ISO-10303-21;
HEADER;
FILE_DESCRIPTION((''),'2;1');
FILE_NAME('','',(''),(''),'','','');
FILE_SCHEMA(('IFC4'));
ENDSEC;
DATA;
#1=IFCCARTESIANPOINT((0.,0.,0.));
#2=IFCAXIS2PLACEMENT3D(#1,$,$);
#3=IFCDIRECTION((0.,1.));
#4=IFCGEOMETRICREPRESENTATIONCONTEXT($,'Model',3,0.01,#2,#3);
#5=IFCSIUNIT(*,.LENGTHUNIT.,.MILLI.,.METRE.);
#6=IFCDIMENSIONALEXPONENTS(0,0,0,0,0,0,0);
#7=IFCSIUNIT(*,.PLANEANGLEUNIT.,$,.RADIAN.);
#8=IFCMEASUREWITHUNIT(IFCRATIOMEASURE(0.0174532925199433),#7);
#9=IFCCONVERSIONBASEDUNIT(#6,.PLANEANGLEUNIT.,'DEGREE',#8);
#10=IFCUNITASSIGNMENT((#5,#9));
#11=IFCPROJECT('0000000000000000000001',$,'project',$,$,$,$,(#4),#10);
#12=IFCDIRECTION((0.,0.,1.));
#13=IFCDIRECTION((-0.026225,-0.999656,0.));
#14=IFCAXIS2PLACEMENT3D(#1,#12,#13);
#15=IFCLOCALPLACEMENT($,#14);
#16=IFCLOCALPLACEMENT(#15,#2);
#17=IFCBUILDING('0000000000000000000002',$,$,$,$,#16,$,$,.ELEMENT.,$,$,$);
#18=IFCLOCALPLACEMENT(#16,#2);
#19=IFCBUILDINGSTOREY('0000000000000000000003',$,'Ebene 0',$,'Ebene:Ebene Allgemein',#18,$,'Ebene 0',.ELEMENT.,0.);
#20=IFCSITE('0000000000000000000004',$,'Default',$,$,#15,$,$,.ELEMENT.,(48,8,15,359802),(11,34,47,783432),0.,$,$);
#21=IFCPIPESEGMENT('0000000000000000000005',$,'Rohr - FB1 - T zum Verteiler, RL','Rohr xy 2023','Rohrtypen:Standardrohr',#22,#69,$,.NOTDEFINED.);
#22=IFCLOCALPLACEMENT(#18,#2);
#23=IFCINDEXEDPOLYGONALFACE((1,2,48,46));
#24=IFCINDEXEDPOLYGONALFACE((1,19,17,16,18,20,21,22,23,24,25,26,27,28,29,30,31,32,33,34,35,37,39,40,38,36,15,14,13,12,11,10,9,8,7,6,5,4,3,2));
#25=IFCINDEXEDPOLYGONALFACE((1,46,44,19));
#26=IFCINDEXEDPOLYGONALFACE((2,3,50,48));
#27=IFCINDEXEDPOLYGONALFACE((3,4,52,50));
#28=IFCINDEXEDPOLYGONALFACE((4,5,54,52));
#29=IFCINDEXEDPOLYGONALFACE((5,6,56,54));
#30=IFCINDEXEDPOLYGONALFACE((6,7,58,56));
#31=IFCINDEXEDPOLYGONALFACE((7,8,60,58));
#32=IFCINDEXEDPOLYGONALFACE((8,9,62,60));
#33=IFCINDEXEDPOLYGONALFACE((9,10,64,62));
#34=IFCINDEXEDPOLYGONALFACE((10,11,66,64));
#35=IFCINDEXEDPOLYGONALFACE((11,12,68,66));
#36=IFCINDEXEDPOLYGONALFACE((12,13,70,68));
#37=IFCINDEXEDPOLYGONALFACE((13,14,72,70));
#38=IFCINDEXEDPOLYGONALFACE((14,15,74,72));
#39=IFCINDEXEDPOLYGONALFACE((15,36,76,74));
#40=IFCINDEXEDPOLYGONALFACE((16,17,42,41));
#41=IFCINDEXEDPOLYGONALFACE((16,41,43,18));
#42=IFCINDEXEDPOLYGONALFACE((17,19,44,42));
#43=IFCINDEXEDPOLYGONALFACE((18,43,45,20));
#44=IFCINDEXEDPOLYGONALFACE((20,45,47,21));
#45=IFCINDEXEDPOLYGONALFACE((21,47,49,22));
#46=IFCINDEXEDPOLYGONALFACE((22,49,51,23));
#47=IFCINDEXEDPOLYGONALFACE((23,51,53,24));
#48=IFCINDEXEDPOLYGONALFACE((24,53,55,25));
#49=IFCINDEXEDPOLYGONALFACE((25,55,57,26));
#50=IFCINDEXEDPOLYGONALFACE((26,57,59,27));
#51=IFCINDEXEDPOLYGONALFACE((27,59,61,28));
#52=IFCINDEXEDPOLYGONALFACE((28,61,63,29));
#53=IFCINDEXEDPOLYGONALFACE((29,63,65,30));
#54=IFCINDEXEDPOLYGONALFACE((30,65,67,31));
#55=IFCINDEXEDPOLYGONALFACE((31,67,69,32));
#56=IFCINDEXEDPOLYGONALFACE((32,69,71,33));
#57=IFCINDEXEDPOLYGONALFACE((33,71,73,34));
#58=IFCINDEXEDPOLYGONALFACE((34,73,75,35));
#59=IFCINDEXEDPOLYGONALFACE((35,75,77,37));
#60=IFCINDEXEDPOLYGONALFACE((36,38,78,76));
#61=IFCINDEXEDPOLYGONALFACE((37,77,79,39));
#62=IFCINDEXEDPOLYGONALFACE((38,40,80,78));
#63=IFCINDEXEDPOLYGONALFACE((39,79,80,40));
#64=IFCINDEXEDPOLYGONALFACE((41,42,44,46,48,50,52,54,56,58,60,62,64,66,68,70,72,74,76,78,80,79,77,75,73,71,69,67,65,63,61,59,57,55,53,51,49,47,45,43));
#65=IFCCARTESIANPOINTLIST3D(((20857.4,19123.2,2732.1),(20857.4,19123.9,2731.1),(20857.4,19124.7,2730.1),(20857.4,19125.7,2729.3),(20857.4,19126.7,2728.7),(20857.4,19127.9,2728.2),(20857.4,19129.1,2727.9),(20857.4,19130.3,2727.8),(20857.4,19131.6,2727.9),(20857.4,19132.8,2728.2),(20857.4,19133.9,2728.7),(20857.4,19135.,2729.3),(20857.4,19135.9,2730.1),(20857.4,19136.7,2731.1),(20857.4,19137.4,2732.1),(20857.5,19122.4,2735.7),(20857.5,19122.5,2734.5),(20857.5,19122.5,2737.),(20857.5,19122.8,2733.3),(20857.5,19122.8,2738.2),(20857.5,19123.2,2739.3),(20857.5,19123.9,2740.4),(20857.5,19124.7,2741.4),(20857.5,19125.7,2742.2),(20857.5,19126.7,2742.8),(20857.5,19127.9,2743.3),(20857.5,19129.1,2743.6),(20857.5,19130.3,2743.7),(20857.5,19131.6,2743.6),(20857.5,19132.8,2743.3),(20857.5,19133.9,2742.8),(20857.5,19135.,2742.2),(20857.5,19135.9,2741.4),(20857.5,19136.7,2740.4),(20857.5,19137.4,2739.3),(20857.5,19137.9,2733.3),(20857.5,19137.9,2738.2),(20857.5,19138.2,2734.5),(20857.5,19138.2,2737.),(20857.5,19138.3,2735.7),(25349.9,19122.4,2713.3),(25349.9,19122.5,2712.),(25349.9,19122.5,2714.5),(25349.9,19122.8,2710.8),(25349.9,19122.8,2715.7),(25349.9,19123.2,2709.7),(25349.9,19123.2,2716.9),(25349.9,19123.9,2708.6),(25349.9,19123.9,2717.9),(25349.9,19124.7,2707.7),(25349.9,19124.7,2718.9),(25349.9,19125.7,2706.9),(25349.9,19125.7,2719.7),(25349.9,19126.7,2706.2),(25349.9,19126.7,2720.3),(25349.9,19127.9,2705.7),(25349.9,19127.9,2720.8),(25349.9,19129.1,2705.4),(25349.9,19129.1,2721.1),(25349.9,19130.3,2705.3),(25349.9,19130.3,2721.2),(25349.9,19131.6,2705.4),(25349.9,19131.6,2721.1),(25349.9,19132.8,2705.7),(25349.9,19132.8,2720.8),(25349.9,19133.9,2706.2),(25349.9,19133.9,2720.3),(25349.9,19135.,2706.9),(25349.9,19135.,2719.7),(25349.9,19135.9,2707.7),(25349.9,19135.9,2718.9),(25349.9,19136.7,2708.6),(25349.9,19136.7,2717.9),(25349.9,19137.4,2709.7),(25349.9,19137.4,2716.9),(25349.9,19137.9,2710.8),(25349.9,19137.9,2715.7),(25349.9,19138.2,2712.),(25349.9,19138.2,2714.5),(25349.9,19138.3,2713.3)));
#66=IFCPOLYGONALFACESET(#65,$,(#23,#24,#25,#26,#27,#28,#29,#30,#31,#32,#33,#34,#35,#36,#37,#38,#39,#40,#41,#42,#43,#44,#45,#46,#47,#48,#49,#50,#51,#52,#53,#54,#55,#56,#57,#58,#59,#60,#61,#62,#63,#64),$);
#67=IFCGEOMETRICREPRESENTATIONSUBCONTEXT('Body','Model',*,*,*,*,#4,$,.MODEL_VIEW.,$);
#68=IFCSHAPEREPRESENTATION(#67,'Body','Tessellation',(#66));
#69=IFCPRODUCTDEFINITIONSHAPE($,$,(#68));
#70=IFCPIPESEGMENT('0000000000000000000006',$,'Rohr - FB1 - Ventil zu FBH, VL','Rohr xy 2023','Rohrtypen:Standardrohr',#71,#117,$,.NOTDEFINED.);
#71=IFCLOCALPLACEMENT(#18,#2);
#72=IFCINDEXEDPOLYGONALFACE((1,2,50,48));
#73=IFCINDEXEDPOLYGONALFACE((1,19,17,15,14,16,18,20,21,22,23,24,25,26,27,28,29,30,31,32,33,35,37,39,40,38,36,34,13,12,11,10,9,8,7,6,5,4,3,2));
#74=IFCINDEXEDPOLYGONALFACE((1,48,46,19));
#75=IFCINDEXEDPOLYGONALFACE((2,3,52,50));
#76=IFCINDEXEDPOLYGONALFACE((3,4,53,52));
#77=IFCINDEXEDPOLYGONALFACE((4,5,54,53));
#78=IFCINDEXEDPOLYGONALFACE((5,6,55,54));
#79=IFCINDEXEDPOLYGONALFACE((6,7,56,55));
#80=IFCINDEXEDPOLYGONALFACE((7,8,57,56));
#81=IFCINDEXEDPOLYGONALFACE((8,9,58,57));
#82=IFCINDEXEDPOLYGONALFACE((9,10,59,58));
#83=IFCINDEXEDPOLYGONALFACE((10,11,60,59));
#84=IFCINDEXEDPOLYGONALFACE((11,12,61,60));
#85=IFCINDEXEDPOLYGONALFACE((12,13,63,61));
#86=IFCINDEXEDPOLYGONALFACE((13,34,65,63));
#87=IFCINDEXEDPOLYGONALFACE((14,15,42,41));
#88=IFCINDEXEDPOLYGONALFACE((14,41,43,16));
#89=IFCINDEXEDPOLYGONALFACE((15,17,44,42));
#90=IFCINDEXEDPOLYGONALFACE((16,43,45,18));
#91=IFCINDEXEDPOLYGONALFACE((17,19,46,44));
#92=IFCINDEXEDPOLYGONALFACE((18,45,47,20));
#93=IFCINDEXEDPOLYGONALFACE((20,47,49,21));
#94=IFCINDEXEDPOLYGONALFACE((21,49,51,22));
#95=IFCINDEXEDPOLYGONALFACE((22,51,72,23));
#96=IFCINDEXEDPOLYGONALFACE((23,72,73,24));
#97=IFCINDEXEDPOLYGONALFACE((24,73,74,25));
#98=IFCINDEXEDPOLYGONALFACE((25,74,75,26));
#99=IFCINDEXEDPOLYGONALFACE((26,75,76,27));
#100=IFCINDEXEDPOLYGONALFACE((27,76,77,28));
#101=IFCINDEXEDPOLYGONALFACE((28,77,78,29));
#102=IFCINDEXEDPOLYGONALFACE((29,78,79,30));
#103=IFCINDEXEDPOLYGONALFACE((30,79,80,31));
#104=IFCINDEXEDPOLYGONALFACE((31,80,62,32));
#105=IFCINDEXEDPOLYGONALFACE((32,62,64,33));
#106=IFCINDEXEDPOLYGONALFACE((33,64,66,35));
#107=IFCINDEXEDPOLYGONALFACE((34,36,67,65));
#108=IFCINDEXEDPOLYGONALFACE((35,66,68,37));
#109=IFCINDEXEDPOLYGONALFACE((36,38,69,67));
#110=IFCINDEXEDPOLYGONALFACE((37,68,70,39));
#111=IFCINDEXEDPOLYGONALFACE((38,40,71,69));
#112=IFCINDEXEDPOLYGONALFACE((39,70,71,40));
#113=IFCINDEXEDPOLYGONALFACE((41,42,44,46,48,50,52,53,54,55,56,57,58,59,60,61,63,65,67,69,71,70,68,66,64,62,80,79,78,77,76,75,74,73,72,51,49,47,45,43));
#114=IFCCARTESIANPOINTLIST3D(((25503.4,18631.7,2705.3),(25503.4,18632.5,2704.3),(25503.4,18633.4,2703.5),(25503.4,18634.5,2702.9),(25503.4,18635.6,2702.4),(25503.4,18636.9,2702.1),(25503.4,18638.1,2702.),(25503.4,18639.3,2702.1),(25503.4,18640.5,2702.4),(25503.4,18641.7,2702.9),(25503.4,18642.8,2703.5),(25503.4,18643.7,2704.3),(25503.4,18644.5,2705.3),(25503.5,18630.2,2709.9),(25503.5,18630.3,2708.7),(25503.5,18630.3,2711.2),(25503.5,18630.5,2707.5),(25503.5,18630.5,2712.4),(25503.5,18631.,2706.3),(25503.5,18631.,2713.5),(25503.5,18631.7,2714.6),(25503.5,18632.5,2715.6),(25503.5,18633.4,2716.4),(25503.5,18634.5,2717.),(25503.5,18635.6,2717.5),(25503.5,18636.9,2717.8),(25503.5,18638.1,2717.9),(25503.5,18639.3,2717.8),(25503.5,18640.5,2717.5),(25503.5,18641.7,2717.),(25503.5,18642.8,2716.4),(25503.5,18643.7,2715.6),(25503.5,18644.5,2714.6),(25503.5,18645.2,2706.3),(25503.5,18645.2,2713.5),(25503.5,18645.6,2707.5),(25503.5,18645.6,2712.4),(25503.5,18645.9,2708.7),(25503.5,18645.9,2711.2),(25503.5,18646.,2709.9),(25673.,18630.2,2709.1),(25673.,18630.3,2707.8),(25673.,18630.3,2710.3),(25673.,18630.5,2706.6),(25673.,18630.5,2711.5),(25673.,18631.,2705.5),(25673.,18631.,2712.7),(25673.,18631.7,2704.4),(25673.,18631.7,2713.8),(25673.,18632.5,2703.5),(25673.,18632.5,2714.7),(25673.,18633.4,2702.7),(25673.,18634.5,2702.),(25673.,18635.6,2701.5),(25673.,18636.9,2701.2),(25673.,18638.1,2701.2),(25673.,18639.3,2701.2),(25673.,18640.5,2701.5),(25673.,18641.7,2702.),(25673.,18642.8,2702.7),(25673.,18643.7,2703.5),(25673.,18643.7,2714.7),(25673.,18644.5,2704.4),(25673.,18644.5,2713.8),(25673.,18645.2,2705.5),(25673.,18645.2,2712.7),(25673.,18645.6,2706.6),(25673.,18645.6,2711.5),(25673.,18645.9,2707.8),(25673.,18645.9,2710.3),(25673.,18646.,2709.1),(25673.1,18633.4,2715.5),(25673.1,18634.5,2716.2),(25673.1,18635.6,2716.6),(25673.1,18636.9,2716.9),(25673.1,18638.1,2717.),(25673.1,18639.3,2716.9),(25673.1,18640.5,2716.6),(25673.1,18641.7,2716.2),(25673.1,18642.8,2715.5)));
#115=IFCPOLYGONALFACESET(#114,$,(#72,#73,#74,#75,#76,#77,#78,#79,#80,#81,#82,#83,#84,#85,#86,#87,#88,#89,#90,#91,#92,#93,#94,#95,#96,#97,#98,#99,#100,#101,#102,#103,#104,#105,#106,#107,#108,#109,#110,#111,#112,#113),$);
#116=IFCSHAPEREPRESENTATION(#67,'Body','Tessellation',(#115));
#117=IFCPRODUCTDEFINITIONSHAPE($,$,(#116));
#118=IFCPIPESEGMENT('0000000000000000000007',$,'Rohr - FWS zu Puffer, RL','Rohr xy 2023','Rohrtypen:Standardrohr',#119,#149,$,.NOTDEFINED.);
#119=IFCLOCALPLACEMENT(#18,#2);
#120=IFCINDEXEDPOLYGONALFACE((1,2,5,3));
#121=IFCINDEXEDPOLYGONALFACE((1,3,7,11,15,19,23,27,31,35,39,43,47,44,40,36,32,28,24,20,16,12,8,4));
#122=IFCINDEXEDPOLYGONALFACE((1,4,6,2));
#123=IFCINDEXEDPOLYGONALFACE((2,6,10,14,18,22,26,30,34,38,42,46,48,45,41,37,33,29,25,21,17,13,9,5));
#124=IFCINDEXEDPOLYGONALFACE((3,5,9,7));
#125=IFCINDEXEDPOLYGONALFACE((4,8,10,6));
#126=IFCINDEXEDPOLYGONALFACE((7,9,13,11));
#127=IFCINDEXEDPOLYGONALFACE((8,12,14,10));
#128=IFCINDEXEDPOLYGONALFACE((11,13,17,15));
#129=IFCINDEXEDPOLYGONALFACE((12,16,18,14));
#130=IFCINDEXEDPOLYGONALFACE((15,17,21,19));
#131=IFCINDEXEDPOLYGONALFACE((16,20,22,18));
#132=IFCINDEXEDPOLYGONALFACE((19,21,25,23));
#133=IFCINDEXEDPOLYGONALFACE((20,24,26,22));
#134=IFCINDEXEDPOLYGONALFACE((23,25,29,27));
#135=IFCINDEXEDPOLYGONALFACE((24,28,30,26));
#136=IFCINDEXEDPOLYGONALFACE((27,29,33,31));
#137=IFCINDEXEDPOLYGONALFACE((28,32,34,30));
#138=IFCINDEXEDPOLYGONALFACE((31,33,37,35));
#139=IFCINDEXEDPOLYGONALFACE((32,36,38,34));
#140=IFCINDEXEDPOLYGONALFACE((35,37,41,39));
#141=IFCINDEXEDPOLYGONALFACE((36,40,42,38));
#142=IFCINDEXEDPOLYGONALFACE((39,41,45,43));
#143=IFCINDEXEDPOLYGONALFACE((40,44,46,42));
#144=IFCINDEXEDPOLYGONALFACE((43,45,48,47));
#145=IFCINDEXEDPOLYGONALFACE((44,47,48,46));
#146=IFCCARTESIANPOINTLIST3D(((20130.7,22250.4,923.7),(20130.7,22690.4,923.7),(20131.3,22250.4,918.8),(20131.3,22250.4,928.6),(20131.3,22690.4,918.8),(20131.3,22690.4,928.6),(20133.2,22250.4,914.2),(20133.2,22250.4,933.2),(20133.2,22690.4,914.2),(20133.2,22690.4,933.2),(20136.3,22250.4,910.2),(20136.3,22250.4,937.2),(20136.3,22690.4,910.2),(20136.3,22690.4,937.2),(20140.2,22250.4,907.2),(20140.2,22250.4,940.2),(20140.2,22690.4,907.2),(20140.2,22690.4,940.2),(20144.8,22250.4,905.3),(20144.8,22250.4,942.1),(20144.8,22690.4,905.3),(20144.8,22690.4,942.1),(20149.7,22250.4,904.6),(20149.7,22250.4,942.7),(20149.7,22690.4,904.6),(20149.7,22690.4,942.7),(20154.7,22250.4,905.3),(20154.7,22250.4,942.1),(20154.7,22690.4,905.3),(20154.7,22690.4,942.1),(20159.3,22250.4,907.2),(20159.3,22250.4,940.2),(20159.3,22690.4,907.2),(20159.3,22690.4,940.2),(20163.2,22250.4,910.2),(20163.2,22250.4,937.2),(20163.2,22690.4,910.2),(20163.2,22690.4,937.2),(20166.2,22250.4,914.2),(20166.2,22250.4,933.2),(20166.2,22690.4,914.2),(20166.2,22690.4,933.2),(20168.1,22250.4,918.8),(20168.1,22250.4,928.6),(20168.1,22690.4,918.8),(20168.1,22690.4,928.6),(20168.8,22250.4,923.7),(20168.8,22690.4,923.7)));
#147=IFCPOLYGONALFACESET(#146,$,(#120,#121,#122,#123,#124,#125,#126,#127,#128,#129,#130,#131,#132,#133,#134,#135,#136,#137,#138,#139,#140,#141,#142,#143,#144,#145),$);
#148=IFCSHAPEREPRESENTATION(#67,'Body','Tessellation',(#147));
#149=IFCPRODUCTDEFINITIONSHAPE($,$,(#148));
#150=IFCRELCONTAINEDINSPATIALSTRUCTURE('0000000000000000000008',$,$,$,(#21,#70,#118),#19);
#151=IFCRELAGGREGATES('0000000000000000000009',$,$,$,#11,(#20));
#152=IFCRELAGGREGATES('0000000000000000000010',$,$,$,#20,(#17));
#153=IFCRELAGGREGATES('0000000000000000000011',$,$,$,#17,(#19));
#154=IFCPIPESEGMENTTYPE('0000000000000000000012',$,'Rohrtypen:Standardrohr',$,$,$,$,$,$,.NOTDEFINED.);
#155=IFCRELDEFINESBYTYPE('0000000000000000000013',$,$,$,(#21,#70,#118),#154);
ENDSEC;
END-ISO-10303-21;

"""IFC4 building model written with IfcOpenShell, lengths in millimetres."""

from ifc_helpers import new_model, entity, si_unit, converted_unit, direction, frame, origin, place, context, subcontext, project, spatial, indexed_curve, outline, extrude, type_object, element, save


model = new_model("IFC4")

# Units and contexts
model_context = context("Model", 3, precision=0.01, world=origin(), true_north=direction((0.0, 1.0)))
body_context = subcontext(model_context, "Body", "Model", "MODEL_VIEW")
ifc_project = project(units=[si_unit("LENGTHUNIT", "METRE", prefix="MILLI"), converted_unit("PLANEANGLEUNIT", "DEGREE", entity("IfcRatioMeasure", 0.0174532925199433), si_unit("PLANEANGLEUNIT", "RADIAN"), dimensions=[0, 0, 0, 0, 0, 0, 0])], contexts=[model_context])

# Site, building, storey
site_placement = place(None, frame((0.0, 0.0, 0.0), z_axis=(0.0, 0.0, 1.0), x_axis=(-0.026225, -0.999656, 0.0)))
site = spatial("IfcSite", under=ifc_project, at=site_placement, Name="Default", CompositionType="ELEMENT", RefLatitude=(48, 8, 15, 359802), RefLongitude=(11, 34, 47, 783432), RefElevation=0.0)
building_placement = place(site_placement, origin())
building = spatial("IfcBuilding", under=site, at=building_placement, CompositionType="ELEMENT")
storey_placement = place(building_placement, origin())
storey = spatial("IfcBuildingStorey", under=building, at=storey_placement, Name="Ebene 0", ObjectType="Ebene:Ebene Allgemein", LongName="Ebene 0", CompositionType="ELEMENT", Elevation=0.0)

# Pipe segments
pipe_segment_type = type_object("IfcPipeSegmentType", Name="Rohrtypen:Standardrohr", PredefinedType="NOTDEFINED")
pipe_segment_1_placement = place(storey_placement, origin())
element("IfcPipeSegment", 1, at=pipe_segment_1_placement, inside=storey, type_object=pipe_segment_type, Name="Rohr - FB1 - T zum Verteiler, RL", Description="Rohr xy 2023", ObjectType="Rohrtypen:Standardrohr", PredefinedType="NOTDEFINED", context=body_context, shape_type="SweptSolid", body=[
    extrude(outline(indexed_curve([(7.9, 0.0), (7.8, 1.2), (7.6, 2.5), (7.1, 3.6), (6.4, 4.7), (5.6, 5.6), (4.7, 6.4), (3.6, 7.1), (2.5, 7.6), (1.2, 7.8), (0.0, 7.9), (-1.2, 7.8), (-2.5, 7.6), (-3.6, 7.1), (-4.7, 6.4), (-5.6, 5.6), (-6.4, 4.7), (-7.1, 3.6), (-7.6, 2.5), (-7.8, 1.2), (-7.9, 0.0), (-7.8, -1.2), (-7.6, -2.5), (-7.1, -3.6), (-6.4, -4.7), (-5.6, -5.6), (-4.7, -6.4), (-3.6, -7.1), (-2.5, -7.6), (-1.2, -7.8), (0.0, -7.9), (1.2, -7.8), (2.5, -7.6), (3.6, -7.1), (4.7, -6.4), (5.6, -5.6), (6.4, -4.7), (7.1, -3.6), (7.6, -2.5), (7.8, -1.2), (7.9, 0.0)], self_intersect=False)), frame((25349.9, 19130.3, 2713.3), z_axis=(-0.999988, 0.0, 0.005), x_axis=(0.0, 1.0, 0.0)), (0.0, 0.0, 1.0), 4492.5),
])
pipe_segment_2_placement = place(storey_placement, origin())
element("IfcPipeSegment", 2, at=pipe_segment_2_placement, inside=storey, type_object=pipe_segment_type, Name="Rohr - FB1 - Ventil zu FBH, VL", Description="Rohr xy 2023", ObjectType="Rohrtypen:Standardrohr", PredefinedType="NOTDEFINED", context=body_context, shape_type="SweptSolid", body=[
    extrude(outline(indexed_curve([(7.9, 0.0), (7.8, 1.2), (7.6, 2.5), (7.1, 3.6), (6.4, 4.7), (5.6, 5.6), (4.7, 6.4), (3.6, 7.1), (2.5, 7.6), (1.2, 7.8), (0.0, 7.9), (-1.2, 7.8), (-2.5, 7.6), (-3.6, 7.1), (-4.7, 6.4), (-5.6, 5.6), (-6.4, 4.7), (-7.1, 3.6), (-7.6, 2.5), (-7.8, 1.2), (-7.9, 0.0), (-7.8, -1.2), (-7.6, -2.5), (-7.1, -3.6), (-6.4, -4.7), (-5.6, -5.6), (-4.7, -6.4), (-3.6, -7.1), (-2.5, -7.6), (-1.2, -7.8), (0.0, -7.9), (1.2, -7.8), (2.5, -7.6), (3.6, -7.1), (4.7, -6.4), (5.6, -5.6), (6.4, -4.7), (7.1, -3.6), (7.6, -2.5), (7.8, -1.2), (7.9, 0.0)], self_intersect=False)), frame((25503.5, 18638.1, 2709.9), z_axis=(0.999988, 0.0, -0.005), x_axis=(0.0, 1.0, 0.0)), (0.0, 0.0, 1.0), 169.5),
])
pipe_segment_3_placement = place(storey_placement, origin())
element("IfcPipeSegment", 3, at=pipe_segment_3_placement, inside=storey, type_object=pipe_segment_type, Name="Rohr - FWS zu Puffer, RL", Description="Rohr xy 2023", ObjectType="Rohrtypen:Standardrohr", PredefinedType="NOTDEFINED", context=body_context, shape_type="SweptSolid", body=[
    extrude(outline(indexed_curve([(-2.5, -18.9), (2.5, -18.9), (7.3, -17.6), (11.6, -15.1), (15.1, -11.6), (17.6, -7.3), (18.9, -2.5), (18.9, 2.5), (17.6, 7.3), (15.1, 11.6), (11.6, 15.1), (7.3, 17.6), (2.5, 18.9), (-2.5, 18.9), (-7.3, 17.6), (-11.6, 15.1), (-15.1, 11.6), (-17.6, 7.3), (-18.9, 2.5), (-18.9, -2.5), (-17.6, -7.3), (-15.1, -11.6), (-11.6, -15.1), (-7.3, -17.6), (-2.5, -18.9)], self_intersect=False)), frame((20149.7, 22250.4, 923.7), z_axis=(0.0, 1.0, 0.0), x_axis=(0.130526, 0.0, 0.991445)), (0.0, 0.0, 1.0), 440.0),
])

save(model, "model.ifc")
